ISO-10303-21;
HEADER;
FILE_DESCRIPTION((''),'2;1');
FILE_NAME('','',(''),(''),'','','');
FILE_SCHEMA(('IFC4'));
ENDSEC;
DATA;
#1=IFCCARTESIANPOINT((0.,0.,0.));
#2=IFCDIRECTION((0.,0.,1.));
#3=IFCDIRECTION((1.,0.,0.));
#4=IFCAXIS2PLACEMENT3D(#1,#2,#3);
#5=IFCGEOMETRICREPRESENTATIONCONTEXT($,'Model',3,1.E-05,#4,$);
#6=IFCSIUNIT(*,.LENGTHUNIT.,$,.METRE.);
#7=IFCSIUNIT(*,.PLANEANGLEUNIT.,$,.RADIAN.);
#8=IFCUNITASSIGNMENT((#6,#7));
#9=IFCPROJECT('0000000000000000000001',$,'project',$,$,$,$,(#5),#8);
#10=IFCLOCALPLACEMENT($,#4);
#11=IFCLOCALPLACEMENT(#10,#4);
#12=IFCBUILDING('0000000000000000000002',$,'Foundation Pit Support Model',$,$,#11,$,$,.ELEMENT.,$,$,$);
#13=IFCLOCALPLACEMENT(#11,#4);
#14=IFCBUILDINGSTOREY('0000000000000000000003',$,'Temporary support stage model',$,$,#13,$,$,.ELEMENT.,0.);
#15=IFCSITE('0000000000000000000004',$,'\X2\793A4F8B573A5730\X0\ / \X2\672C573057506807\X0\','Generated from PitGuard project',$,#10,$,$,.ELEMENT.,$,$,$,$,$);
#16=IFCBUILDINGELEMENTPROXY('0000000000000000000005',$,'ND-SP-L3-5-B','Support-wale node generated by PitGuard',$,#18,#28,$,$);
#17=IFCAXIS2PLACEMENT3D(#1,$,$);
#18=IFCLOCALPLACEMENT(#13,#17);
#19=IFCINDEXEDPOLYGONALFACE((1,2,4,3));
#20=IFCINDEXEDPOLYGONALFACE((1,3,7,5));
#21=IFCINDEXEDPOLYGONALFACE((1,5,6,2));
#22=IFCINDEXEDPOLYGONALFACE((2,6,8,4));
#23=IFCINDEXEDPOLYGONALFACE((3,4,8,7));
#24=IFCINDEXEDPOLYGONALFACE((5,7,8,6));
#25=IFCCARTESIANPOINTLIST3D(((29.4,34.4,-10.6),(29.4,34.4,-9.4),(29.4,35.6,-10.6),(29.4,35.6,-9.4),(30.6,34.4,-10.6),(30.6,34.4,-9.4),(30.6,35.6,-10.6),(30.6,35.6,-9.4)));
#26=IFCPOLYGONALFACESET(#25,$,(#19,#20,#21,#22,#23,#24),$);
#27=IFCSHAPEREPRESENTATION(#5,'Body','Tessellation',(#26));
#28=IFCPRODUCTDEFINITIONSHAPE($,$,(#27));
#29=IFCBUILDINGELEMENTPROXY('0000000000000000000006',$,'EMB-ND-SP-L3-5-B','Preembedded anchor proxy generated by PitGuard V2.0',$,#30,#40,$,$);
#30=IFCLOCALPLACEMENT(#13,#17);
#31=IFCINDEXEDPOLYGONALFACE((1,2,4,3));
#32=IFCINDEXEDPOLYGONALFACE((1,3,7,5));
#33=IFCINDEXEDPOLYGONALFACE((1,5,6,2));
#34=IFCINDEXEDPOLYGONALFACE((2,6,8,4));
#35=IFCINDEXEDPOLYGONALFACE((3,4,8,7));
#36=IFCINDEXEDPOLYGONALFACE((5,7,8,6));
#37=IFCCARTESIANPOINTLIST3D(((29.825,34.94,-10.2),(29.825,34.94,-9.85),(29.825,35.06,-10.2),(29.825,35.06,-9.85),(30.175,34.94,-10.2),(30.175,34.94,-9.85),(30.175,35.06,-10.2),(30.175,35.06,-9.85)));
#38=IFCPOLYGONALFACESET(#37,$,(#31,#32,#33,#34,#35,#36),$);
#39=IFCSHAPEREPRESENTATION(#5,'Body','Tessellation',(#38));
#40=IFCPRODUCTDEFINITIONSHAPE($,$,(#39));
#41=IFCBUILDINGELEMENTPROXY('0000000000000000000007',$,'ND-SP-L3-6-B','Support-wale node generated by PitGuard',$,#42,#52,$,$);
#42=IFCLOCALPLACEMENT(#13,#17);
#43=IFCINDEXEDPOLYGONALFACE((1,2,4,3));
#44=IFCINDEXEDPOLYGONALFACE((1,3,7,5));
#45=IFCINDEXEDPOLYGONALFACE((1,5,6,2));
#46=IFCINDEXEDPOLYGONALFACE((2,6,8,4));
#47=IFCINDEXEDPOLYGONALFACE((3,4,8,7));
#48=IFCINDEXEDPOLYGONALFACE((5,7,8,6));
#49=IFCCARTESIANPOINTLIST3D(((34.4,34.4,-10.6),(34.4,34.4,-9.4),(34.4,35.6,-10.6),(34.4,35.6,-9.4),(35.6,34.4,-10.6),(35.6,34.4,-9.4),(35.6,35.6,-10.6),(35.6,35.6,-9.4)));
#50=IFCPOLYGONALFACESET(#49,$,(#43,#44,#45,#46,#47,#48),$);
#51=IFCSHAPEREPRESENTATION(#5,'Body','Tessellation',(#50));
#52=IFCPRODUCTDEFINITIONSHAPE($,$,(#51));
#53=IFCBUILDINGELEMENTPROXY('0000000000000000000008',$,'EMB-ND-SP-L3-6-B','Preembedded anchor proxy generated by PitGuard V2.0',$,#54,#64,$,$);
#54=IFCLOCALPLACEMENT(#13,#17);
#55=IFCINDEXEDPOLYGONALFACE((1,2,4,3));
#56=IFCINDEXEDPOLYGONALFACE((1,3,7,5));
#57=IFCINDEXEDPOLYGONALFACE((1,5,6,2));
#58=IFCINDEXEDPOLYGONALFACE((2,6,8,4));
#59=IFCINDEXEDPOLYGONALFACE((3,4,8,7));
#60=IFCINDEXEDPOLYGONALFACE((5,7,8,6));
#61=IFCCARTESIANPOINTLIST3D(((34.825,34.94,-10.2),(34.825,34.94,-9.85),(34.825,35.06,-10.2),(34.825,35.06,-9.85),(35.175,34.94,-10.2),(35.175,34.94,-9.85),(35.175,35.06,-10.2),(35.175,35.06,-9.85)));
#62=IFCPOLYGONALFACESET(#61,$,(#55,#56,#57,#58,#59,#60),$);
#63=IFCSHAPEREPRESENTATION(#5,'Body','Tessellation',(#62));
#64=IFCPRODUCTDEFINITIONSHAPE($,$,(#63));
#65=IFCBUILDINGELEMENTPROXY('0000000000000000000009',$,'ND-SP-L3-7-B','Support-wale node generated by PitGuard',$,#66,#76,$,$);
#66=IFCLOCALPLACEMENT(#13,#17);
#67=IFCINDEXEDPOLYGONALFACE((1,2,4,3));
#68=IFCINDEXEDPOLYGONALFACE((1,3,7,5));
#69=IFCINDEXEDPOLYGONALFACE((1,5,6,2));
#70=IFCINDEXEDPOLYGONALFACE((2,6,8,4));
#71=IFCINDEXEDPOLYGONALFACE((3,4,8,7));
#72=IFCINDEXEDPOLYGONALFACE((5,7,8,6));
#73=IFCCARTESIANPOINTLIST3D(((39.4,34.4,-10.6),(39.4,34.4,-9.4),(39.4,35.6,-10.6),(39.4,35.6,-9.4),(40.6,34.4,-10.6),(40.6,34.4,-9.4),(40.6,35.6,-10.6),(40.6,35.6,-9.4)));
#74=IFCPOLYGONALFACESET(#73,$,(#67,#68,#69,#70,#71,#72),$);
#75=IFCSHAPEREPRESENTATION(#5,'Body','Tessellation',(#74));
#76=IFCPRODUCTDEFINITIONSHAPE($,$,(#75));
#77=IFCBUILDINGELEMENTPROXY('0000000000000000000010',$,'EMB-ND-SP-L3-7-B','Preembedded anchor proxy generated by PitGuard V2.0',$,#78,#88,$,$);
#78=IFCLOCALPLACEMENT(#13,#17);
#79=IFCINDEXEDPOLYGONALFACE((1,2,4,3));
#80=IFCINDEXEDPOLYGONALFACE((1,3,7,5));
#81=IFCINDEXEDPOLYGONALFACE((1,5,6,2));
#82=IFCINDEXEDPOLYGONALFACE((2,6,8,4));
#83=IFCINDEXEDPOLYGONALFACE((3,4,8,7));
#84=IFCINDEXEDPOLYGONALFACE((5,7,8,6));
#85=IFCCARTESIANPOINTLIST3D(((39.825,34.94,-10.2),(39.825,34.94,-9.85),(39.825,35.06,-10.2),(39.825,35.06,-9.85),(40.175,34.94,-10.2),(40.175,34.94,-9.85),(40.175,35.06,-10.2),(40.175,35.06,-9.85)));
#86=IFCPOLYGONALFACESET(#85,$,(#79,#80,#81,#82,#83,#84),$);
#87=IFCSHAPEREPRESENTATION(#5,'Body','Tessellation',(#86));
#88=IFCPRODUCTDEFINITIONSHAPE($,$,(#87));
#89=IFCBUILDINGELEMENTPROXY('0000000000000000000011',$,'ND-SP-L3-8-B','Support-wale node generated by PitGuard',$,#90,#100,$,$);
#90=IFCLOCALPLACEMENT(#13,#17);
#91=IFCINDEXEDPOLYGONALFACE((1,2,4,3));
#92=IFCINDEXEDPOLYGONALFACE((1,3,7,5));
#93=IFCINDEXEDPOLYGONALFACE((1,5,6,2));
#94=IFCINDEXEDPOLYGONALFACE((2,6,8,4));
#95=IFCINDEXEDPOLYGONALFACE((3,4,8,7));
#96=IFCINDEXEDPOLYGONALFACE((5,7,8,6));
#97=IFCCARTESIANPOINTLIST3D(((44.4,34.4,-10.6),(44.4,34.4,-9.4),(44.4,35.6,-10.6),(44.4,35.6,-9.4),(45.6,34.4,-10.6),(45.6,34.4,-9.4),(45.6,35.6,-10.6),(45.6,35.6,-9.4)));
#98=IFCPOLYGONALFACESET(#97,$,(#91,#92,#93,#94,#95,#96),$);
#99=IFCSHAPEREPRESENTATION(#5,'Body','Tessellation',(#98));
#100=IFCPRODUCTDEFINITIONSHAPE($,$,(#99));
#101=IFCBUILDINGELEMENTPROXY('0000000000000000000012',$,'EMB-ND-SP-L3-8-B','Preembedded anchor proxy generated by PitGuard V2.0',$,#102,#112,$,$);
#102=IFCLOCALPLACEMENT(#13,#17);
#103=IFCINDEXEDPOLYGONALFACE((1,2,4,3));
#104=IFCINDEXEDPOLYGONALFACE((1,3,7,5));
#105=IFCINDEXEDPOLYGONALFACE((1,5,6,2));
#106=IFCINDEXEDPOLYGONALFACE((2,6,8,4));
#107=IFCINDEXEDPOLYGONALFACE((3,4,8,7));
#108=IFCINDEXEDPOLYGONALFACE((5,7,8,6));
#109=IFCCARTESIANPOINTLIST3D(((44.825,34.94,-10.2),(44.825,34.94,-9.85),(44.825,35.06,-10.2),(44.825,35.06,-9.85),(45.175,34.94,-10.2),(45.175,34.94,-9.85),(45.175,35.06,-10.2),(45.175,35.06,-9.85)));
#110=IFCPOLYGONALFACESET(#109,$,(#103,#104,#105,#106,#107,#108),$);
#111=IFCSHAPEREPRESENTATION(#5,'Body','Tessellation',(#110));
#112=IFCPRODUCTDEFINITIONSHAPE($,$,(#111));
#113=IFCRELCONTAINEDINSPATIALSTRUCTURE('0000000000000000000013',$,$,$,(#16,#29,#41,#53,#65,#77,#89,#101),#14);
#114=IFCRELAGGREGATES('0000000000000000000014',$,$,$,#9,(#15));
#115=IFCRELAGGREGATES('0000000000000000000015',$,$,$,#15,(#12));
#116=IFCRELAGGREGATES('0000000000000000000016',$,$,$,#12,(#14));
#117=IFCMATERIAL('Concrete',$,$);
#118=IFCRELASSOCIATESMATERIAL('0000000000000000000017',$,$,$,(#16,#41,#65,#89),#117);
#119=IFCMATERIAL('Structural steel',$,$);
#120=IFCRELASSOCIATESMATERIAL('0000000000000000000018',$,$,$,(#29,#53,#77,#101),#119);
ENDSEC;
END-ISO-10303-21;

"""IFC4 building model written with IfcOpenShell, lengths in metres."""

from ifc_helpers import new_model, si_unit, frame, origin_with_axes, origin_2d, place, context, project, spatial, rectangle, extrude, material, element, save


model = new_model("IFC4")

# Units and contexts
model_context = context("Model", 3, precision=1e-05, world=origin_with_axes())
ifc_project = project(units=[si_unit("LENGTHUNIT", "METRE"), si_unit("PLANEANGLEUNIT", "RADIAN")], contexts=[model_context])

# Site, building, storey
site_placement = place(None, origin_with_axes())
site = spatial("IfcSite", under=ifc_project, at=site_placement, Name="示例场地 / 本地坐标", Description="Generated from PitGuard project", CompositionType="ELEMENT")
building_placement = place(site_placement, origin_with_axes())
building = spatial("IfcBuilding", under=site, at=building_placement, Name="Foundation Pit Support Model", CompositionType="ELEMENT")
storey_placement = place(building_placement, origin_with_axes())
storey = spatial("IfcBuildingStorey", under=building, at=storey_placement, Name="Temporary support stage model", CompositionType="ELEMENT", Elevation=0.0)

# Shared definitions
ifc_material_1 = material(Name="Structural steel")

# Shared definitions
ifc_material_2 = material(Name="Concrete")

# Building element proxies
for number, where, z_axis, x_axis, name in (
    (1, (30.0, 35.0, -10.6), (0.0, 0.0, 1.0), (1.0, 0.0, 0.0), "ND-SP-L3-5-B"),
):
    element("IfcBuildingElementProxy", number, at=place(storey_placement, frame(where, z_axis=z_axis, x_axis=x_axis)), inside=storey, material=ifc_material_2, Name=name, Description="Support-wale node generated by PitGuard", context=model_context, shape_type="SweptSolid", body=[
        extrude(rectangle(XDim=1.2, YDim=1.2, at=origin_2d()), origin_with_axes(), (0.0, 0.0, 1.0), 1.2),
    ])
proxy_1_placement = place(storey_placement, frame((30.0, 35.0, -10.2), z_axis=(0.0, 0.0, 1.0), x_axis=(1.0, 0.0, 0.0)))
element("IfcBuildingElementProxy", 2, at=proxy_1_placement, inside=storey, material=ifc_material_1, Name="EMB-ND-SP-L3-5-B", Description="Preembedded anchor proxy generated by PitGuard V2.0", context=model_context, shape_type="SweptSolid", body=[
    extrude(rectangle(XDim=0.35, YDim=0.12, at=origin_2d()), origin_with_axes(), (0.0, 0.0, 1.0), 0.35),
])
proxy_2_placement = place(storey_placement, frame((35.0, 35.0, -10.6), z_axis=(0.0, 0.0, 1.0), x_axis=(1.0, 0.0, 0.0)))
element("IfcBuildingElementProxy", 3, at=proxy_2_placement, inside=storey, material=ifc_material_2, Name="ND-SP-L3-6-B", Description="Support-wale node generated by PitGuard", context=model_context, shape_type="SweptSolid", body=[
    extrude(rectangle(XDim=1.2, YDim=1.2, at=origin_2d()), origin_with_axes(), (0.0, 0.0, 1.0), 1.2),
])
proxy_3_placement = place(storey_placement, frame((35.0, 35.0, -10.2), z_axis=(0.0, 0.0, 1.0), x_axis=(1.0, 0.0, 0.0)))
element("IfcBuildingElementProxy", 4, at=proxy_3_placement, inside=storey, material=ifc_material_1, Name="EMB-ND-SP-L3-6-B", Description="Preembedded anchor proxy generated by PitGuard V2.0", context=model_context, shape_type="SweptSolid", body=[
    extrude(rectangle(XDim=0.35, YDim=0.12, at=origin_2d()), origin_with_axes(), (0.0, 0.0, 1.0), 0.35),
])
proxy_4_placement = place(storey_placement, frame((40.0, 35.0, -10.6), z_axis=(0.0, 0.0, 1.0), x_axis=(1.0, 0.0, 0.0)))
element("IfcBuildingElementProxy", 5, at=proxy_4_placement, inside=storey, material=ifc_material_2, Name="ND-SP-L3-7-B", Description="Support-wale node generated by PitGuard", context=model_context, shape_type="SweptSolid", body=[
    extrude(rectangle(XDim=1.2, YDim=1.2, at=origin_2d()), origin_with_axes(), (0.0, 0.0, 1.0), 1.2),
])
proxy_5_placement = place(storey_placement, frame((40.0, 35.0, -10.2), z_axis=(0.0, 0.0, 1.0), x_axis=(1.0, 0.0, 0.0)))
element("IfcBuildingElementProxy", 6, at=proxy_5_placement, inside=storey, material=ifc_material_1, Name="EMB-ND-SP-L3-7-B", Description="Preembedded anchor proxy generated by PitGuard V2.0", context=model_context, shape_type="SweptSolid", body=[
    extrude(rectangle(XDim=0.35, YDim=0.12, at=origin_2d()), origin_with_axes(), (0.0, 0.0, 1.0), 0.35),
])
proxy_6_placement = place(storey_placement, frame((45.0, 35.0, -10.6), z_axis=(0.0, 0.0, 1.0), x_axis=(1.0, 0.0, 0.0)))
element("IfcBuildingElementProxy", 7, at=proxy_6_placement, inside=storey, material=ifc_material_2, Name="ND-SP-L3-8-B", Description="Support-wale node generated by PitGuard", context=model_context, shape_type="SweptSolid", body=[
    extrude(rectangle(XDim=1.2, YDim=1.2, at=origin_2d()), origin_with_axes(), (0.0, 0.0, 1.0), 1.2),
])
proxy_7_placement = place(storey_placement, frame((45.0, 35.0, -10.2), z_axis=(0.0, 0.0, 1.0), x_axis=(1.0, 0.0, 0.0)))
element("IfcBuildingElementProxy", 8, at=proxy_7_placement, inside=storey, material=ifc_material_1, Name="EMB-ND-SP-L3-8-B", Description="Preembedded anchor proxy generated by PitGuard V2.0", context=model_context, shape_type="SweptSolid", body=[
    extrude(rectangle(XDim=0.35, YDim=0.12, at=origin_2d()), origin_with_axes(), (0.0, 0.0, 1.0), 0.35),
])

save(model, "model.ifc")
